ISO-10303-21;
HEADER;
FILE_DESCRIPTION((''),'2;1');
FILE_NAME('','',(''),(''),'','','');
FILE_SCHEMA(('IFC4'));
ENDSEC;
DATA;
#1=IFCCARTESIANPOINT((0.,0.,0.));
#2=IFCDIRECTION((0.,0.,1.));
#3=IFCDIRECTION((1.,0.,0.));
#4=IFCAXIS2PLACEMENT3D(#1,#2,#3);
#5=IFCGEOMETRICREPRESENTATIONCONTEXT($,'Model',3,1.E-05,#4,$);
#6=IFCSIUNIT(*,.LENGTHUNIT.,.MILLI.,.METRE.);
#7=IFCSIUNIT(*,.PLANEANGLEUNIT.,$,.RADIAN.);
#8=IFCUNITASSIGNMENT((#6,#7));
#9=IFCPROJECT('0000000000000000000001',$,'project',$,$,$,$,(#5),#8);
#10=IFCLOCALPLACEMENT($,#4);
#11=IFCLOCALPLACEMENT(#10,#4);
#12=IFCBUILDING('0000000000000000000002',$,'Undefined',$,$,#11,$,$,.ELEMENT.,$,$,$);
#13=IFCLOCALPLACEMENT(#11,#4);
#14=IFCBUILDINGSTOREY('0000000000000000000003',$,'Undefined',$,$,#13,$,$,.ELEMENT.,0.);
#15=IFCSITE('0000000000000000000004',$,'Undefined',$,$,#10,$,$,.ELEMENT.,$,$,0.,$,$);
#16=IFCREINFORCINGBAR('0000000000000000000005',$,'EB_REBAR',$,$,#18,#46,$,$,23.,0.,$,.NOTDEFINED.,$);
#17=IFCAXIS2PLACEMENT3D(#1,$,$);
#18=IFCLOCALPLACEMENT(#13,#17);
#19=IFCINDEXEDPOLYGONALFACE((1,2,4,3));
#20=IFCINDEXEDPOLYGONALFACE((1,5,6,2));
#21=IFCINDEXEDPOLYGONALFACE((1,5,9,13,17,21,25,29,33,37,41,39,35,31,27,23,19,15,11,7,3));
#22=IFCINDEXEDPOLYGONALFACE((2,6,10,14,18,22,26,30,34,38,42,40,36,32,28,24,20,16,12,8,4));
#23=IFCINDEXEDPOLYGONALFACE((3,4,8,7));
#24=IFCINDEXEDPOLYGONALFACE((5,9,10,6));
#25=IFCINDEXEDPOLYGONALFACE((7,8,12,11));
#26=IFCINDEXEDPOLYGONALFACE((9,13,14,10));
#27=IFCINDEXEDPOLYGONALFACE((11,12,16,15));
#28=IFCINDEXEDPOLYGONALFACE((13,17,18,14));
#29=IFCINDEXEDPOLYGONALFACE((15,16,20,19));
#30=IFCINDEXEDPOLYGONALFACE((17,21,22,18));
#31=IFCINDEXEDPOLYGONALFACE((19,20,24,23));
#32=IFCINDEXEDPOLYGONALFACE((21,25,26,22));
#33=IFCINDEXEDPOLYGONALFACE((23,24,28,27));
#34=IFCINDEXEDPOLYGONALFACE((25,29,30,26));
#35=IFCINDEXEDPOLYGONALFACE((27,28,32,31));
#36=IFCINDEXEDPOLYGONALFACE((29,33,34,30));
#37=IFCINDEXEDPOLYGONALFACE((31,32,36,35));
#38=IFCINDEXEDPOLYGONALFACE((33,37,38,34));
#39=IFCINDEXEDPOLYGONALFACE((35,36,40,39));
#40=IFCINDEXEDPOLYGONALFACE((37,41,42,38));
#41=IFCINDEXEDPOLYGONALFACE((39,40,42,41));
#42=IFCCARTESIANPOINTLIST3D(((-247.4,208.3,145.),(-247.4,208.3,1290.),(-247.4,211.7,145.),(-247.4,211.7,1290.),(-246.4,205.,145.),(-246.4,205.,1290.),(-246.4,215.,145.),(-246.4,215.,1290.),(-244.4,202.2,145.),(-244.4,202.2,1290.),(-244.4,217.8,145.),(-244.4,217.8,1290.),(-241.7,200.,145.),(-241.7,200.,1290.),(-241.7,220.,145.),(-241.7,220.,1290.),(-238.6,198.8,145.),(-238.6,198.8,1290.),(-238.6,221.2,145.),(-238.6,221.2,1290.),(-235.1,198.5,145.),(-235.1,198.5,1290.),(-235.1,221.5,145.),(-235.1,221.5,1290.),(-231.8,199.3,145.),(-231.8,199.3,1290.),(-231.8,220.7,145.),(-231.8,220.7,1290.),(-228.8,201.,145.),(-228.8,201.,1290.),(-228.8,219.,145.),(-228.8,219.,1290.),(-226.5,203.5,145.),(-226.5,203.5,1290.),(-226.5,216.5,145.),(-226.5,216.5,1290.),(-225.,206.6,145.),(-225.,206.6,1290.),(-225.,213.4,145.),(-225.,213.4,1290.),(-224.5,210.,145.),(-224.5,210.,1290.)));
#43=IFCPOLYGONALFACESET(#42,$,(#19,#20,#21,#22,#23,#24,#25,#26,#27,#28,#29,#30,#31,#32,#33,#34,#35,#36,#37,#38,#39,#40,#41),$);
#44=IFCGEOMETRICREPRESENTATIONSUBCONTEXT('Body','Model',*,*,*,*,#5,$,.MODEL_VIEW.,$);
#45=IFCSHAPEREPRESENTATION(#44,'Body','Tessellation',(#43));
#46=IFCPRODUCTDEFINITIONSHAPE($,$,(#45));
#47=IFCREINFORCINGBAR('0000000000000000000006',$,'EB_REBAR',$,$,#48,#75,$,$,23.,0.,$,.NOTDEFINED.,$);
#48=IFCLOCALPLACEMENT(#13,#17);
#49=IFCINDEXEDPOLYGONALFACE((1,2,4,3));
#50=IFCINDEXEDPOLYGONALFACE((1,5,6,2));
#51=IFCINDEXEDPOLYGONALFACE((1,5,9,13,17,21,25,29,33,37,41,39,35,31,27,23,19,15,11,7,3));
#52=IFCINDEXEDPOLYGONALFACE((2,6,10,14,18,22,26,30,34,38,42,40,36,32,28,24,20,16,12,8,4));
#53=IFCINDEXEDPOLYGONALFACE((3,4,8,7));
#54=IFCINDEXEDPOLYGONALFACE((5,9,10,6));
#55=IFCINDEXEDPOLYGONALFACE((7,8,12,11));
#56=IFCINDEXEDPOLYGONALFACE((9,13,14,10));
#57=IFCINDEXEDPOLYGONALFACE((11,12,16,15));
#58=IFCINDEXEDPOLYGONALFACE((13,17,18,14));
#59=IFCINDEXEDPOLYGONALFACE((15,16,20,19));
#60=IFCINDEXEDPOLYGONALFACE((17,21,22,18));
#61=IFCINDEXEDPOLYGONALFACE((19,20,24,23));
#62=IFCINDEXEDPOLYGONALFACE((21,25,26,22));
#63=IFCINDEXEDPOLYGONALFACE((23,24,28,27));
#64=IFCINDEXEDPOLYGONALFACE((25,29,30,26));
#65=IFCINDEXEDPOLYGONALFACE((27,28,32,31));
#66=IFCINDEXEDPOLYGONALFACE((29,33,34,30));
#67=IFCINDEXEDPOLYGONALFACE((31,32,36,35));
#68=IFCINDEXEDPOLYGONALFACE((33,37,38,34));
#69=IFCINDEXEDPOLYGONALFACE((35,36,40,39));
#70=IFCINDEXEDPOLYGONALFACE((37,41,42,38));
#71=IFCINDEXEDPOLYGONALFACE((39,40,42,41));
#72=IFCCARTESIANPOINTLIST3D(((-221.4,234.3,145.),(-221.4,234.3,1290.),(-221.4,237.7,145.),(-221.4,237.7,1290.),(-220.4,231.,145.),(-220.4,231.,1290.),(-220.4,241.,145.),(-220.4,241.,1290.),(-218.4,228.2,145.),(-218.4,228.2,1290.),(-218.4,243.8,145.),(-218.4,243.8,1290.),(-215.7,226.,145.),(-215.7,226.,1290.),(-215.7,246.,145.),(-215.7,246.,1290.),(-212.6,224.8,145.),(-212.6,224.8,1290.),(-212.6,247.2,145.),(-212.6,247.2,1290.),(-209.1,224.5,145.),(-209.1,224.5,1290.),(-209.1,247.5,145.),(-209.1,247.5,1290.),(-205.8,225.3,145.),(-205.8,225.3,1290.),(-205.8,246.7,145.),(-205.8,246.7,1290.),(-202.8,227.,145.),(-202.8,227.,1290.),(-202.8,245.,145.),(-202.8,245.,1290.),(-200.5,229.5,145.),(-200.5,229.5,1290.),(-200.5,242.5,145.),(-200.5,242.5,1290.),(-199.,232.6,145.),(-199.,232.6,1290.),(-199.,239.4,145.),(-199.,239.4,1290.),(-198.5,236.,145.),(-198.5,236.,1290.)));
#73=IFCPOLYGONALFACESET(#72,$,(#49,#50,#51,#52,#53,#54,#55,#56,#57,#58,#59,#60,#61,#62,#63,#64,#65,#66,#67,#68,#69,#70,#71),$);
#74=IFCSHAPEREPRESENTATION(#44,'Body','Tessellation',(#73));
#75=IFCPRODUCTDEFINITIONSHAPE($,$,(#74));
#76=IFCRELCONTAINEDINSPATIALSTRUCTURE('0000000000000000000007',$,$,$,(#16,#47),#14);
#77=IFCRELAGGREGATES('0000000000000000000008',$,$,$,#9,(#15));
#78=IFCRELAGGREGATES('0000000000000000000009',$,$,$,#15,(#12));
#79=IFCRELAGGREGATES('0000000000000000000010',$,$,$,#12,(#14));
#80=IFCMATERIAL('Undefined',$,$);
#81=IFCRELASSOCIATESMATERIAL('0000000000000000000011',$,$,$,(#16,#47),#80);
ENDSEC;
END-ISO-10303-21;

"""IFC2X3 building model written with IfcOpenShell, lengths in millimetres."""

from ifc_helpers import new_model, entity, si_unit, frame, origin_with_axes, place, context, subcontext, project, spatial, source, transform, mapped, material, element, save


model = new_model("IFC2X3")

# Units and contexts
model_context = context("Model", 3, precision=1e-05, world=origin_with_axes())
body_context = subcontext(model_context, "Body", "Model", "MODEL_VIEW")
ifc_project = project(units=[si_unit("LENGTHUNIT", "METRE", prefix="MILLI"), si_unit("PLANEANGLEUNIT", "RADIAN")], contexts=[model_context])

# Site, building, storey
site_placement = place(None, origin_with_axes())
site = spatial("IfcSite", under=ifc_project, at=site_placement, Name="Undefined", CompositionType="ELEMENT", RefElevation=0.0)
building_placement = place(site_placement, origin_with_axes())
building = spatial("IfcBuilding", under=site, at=building_placement, Name="Undefined", CompositionType="ELEMENT")
storey_placement = place(building_placement, origin_with_axes())
storey = spatial("IfcBuildingStorey", under=building, at=storey_placement, Name="Undefined", CompositionType="ELEMENT", Elevation=0.0)

# Reinforcing bars
ifc_material_1 = material(Name="Undefined")
shared_shape_1 = source(origin_with_axes(), body_context, "Body", "AdvancedSweptSolid", [
    entity("IfcSweptDiskSolid", entity("IfcTrimmedCurve", entity("IfcLine", entity("IfcCartesianPoint", [0.0, 0.0, 0.0]), entity("IfcVector", entity("IfcDirection", [1.0, 0.0, 0.0]), 1.0)), [entity("IfcParameterValue", 0.0)], [entity("IfcParameterValue", 1144.999881)], True, "PARAMETER"), 11.5, None, 0.0, 1145.0),
])
reinforcing_bar_1_placement = place(storey_placement, frame((-236.0, 210.0, 145.0), z_axis=(1.0, 0.0, 0.0), x_axis=(0.0, 0.0, 1.0)))
element("IfcReinforcingBar", 1, at=reinforcing_bar_1_placement, inside=storey, material=ifc_material_1, Name="EB_REBAR", BarRole="NOTDEFINED", CrossSectionArea=0.0, NominalDiameter=23.0, context=body_context, shape_type="MappedRepresentation", body=[
    mapped(shared_shape_1, transform((0.0, 0.0, 0.0))),
])
shared_shape_2 = source(origin_with_axes(), body_context, "Body", "AdvancedSweptSolid", [
    entity("IfcSweptDiskSolid", entity("IfcTrimmedCurve", entity("IfcLine", entity("IfcCartesianPoint", [0.0, 0.0, 0.0]), entity("IfcVector", entity("IfcDirection", [1.0, 0.0, 0.0]), 1.0)), [entity("IfcParameterValue", 0.0)], [entity("IfcParameterValue", 1144.999996)], True, "PARAMETER"), 11.5, None, 0.0, 1145.0),
])
reinforcing_bar_2_placement = place(storey_placement, frame((-210.0, 236.0, 145.0), z_axis=(1.0, 0.0, 0.0), x_axis=(0.0, 0.0, 1.0)))
element("IfcReinforcingBar", 2, at=reinforcing_bar_2_placement, inside=storey, material=ifc_material_1, Name="EB_REBAR", BarRole="NOTDEFINED", CrossSectionArea=0.0, NominalDiameter=23.0, context=body_context, shape_type="MappedRepresentation", body=[
    mapped(shared_shape_2, transform((0.0, 0.0, 0.0))),
])

save(model, "model.ifc")
